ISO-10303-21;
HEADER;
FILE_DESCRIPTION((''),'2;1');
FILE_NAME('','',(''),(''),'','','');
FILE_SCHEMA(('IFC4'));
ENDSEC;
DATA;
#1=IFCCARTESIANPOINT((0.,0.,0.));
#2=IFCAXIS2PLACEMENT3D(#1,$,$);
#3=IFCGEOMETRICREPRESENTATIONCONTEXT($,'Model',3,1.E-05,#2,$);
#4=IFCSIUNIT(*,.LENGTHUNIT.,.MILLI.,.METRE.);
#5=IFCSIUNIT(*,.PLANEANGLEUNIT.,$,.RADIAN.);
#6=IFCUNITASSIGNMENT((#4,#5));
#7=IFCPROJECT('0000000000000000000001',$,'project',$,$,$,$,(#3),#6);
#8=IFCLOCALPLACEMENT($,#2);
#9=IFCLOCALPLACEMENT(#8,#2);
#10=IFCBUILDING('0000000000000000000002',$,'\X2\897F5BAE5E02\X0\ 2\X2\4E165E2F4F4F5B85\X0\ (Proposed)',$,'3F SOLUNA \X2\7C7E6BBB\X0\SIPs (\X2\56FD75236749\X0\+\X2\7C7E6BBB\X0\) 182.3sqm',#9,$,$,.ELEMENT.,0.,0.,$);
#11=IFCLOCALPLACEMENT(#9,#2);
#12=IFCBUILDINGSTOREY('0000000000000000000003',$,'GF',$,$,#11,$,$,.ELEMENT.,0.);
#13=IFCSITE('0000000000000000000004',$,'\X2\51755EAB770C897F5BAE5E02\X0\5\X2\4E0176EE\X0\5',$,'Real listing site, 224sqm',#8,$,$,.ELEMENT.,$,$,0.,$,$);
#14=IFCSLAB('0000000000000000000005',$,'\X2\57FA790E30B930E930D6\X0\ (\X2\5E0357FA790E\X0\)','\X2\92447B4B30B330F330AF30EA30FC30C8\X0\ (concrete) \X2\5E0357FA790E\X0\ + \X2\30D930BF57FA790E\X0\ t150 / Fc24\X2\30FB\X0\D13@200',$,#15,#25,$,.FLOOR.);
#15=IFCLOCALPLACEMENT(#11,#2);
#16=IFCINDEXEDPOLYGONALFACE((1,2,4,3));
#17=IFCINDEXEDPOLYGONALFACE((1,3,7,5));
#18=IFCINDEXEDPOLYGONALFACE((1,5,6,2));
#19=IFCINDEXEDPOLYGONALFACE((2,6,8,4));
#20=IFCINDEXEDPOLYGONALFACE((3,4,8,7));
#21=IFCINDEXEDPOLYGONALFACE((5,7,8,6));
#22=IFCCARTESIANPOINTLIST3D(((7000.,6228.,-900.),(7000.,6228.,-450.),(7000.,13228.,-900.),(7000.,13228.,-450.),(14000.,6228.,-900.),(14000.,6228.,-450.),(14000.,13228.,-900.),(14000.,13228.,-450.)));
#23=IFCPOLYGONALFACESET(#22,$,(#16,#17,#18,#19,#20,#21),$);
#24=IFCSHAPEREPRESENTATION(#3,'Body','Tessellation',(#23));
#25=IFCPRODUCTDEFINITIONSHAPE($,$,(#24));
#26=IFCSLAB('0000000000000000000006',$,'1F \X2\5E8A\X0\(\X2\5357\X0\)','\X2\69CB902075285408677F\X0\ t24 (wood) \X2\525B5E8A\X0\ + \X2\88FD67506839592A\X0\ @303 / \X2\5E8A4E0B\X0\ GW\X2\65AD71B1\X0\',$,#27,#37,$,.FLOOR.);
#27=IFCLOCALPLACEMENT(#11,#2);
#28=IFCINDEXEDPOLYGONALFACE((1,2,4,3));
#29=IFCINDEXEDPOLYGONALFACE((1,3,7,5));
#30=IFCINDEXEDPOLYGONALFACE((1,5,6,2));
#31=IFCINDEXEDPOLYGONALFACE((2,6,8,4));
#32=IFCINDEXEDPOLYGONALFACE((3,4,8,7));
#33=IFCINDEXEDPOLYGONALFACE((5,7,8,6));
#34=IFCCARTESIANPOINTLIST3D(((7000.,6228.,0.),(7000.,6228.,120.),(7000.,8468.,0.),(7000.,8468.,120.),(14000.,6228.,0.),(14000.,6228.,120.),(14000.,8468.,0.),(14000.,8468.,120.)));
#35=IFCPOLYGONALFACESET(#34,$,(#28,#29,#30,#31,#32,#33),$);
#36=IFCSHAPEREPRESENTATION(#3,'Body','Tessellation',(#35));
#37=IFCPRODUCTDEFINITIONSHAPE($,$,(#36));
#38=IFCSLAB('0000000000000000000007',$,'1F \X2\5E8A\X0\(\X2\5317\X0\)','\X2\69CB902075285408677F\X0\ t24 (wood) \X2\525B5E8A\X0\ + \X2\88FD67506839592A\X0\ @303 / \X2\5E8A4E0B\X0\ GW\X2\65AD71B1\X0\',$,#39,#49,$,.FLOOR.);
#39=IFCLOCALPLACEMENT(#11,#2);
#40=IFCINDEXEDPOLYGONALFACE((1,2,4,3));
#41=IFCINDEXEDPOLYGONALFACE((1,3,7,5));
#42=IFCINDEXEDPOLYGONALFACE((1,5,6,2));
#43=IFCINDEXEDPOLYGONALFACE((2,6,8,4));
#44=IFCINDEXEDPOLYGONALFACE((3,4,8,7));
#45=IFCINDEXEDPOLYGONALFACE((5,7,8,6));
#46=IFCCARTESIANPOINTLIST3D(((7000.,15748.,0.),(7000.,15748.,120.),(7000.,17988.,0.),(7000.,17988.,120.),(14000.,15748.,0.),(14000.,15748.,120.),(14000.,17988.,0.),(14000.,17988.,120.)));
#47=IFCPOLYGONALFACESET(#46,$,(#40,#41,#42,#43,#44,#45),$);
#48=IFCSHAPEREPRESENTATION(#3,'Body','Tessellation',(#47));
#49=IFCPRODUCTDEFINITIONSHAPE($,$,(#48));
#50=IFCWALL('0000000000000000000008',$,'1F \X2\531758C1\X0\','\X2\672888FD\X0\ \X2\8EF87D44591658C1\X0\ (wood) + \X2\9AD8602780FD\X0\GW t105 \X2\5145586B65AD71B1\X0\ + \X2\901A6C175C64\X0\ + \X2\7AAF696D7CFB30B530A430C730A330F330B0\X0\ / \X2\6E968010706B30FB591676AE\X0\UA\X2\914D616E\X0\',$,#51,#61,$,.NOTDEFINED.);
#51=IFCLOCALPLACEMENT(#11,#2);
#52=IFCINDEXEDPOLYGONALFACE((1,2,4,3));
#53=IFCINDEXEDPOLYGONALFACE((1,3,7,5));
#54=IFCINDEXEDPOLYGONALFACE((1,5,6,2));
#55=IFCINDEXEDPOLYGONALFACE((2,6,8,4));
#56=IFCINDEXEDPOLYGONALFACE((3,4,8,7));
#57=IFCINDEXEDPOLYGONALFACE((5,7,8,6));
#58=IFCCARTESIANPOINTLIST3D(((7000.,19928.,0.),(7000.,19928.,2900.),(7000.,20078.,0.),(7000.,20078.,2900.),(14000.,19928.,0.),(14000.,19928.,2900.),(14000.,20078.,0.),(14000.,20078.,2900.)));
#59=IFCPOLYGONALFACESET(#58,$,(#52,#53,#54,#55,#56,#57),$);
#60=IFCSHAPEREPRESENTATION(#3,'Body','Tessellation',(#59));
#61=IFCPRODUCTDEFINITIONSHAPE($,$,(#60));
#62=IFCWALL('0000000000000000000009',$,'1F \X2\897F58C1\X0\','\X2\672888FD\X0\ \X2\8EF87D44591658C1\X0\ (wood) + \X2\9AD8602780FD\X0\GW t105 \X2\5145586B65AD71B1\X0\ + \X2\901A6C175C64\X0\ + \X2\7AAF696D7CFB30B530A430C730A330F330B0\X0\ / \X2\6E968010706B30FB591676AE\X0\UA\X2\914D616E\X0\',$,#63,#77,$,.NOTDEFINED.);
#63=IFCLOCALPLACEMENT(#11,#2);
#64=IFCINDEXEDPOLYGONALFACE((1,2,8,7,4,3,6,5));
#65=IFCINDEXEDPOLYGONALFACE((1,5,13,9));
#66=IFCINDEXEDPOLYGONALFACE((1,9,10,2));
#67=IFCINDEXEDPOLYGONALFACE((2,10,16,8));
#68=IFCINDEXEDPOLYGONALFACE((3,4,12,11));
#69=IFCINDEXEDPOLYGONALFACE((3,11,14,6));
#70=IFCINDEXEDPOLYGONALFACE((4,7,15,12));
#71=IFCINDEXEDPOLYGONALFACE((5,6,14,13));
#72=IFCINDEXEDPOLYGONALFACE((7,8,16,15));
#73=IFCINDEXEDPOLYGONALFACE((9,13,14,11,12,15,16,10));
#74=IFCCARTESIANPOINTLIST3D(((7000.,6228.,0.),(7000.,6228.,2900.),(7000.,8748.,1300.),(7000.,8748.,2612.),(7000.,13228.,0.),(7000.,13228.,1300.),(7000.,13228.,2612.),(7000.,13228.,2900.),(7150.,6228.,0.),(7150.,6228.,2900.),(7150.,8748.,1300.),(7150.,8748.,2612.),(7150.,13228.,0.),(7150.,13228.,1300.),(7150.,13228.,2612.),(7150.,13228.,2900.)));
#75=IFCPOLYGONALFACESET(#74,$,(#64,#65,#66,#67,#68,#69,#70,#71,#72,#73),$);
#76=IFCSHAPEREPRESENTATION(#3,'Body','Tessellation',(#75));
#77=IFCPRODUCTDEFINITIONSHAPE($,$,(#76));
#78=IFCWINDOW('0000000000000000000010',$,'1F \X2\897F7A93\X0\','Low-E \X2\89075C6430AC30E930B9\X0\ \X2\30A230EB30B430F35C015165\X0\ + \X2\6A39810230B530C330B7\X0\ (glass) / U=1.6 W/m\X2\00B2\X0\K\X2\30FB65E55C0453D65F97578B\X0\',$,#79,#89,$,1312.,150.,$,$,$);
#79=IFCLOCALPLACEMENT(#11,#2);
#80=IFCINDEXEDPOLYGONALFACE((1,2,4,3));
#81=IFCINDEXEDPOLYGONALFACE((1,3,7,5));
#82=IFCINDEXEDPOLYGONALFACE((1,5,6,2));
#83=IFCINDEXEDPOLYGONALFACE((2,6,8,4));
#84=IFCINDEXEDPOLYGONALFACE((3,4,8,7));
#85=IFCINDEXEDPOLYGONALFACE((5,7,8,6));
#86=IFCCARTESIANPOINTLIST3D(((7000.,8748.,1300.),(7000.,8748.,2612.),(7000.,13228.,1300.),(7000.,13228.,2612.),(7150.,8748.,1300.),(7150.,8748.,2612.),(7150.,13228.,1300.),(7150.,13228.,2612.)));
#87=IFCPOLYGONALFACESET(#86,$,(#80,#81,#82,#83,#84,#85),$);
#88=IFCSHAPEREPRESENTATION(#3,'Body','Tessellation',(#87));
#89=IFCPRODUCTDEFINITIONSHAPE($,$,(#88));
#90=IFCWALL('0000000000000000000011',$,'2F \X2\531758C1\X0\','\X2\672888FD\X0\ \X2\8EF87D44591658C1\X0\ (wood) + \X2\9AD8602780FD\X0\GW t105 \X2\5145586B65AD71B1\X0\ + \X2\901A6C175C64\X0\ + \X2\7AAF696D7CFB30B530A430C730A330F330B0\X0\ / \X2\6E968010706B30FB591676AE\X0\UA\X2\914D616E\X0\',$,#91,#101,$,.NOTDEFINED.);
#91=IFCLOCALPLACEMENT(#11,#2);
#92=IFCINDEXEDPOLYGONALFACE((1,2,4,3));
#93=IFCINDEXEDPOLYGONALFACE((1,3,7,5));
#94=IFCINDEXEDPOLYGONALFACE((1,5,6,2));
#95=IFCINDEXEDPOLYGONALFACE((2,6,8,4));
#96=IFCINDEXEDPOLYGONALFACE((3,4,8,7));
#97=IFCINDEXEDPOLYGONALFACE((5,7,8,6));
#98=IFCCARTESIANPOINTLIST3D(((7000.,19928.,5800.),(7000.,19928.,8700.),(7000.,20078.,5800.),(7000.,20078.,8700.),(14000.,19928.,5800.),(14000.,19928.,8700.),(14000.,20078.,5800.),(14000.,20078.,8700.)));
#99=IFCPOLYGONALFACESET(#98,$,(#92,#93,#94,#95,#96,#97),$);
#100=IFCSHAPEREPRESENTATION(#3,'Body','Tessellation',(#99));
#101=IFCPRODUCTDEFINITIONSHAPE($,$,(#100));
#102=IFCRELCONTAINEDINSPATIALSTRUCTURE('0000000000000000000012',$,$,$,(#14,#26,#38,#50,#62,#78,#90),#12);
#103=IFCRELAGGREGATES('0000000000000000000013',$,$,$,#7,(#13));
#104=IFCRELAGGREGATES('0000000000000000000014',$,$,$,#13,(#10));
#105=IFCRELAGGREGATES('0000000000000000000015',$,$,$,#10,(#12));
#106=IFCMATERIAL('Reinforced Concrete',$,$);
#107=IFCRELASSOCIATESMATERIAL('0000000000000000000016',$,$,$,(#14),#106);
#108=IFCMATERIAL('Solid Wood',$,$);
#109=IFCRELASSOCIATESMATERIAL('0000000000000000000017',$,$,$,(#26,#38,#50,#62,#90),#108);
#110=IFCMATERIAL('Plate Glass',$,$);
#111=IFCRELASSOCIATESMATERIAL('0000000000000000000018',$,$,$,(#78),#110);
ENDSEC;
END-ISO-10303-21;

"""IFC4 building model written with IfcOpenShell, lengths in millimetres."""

from ifc_helpers import new_model, si_unit, frame, frame_2d, origin, place, context, project, spatial, rectangle, extrude, material, element, fill, save


model = new_model("IFC4")

# Units and contexts
model_context = context("Model", 3, precision=1e-05, world=origin())
ifc_project = project(units=[si_unit("LENGTHUNIT", "METRE", prefix="MILLI"), si_unit("PLANEANGLEUNIT", "RADIAN")], contexts=[model_context])

# Site, building, storey
site_placement = place(None, origin())
site = spatial("IfcSite", under=ifc_project, at=site_placement, Name="兵庫県西宮市5丁目5", ObjectType="Real listing site, 224sqm", CompositionType="ELEMENT", RefElevation=0.0)
building_placement = place(site_placement, origin())
building = spatial("IfcBuilding", under=site, at=building_placement, Name="西宮市 2世帯住宅 (Proposed)", ObjectType="3F SOLUNA 籾殻SIPs (国産杉+籾殻) 182.3sqm", CompositionType="ELEMENT", ElevationOfRefHeight=0.0, ElevationOfTerrain=0.0)
storey_placement = place(building_placement, origin())
storey = spatial("IfcBuildingStorey", under=building, at=storey_placement, Name="GF", CompositionType="ELEMENT", Elevation=0.0)

# Slabs
ifc_material_1 = material(Name="Reinforced Concrete")
slab_1_placement = place(storey_placement, frame((3500.0, 3114.0, -450.0)))
element("IfcSlab", 1, at=slab_1_placement, inside=storey, material=ifc_material_1, Name="基礎スラブ (布基礎)", Description="鉄筋コンクリート (concrete) 布基礎 + ベタ基礎 t150 / Fc24・D13@200", PredefinedType="FLOOR", context=model_context, shape_type="SweptSolid", body=[
    extrude(rectangle(XDim=7000.0, YDim=7000.0, at=frame_2d((3500.0, 3500.0))), frame((3500.0, 3114.0, -450.0)), (0.0, 0.0, 1.0), 450.0),
])
ifc_material_2 = material(Name="Solid Wood")
slab_2_placement = place(storey_placement, frame((3500.0, 3114.0, 0.0)))
element("IfcSlab", 2, at=slab_2_placement, inside=storey, material=ifc_material_2, Name="1F 床(南)", Description="構造用合板 t24 (wood) 剛床 + 製材根太 @303 / 床下 GW断熱", PredefinedType="FLOOR", context=model_context, shape_type="SweptSolid", body=[
    extrude(rectangle(XDim=7000.0, YDim=2240.0, at=frame_2d((3500.0, 1120.0))), frame((3500.0, 3114.0, 0.0)), (0.0, 0.0, 1.0), 120.0),
])
slab_3_placement = place(storey_placement, frame((3500.0, 7874.0, 0.0)))
element("IfcSlab", 3, at=slab_3_placement, inside=storey, material=ifc_material_2, Name="1F 床(北)", Description="構造用合板 t24 (wood) 剛床 + 製材根太 @303 / 床下 GW断熱", PredefinedType="FLOOR", context=model_context, shape_type="SweptSolid", body=[
    extrude(rectangle(XDim=7000.0, YDim=2240.0, at=frame_2d((3500.0, 1120.0))), frame((3500.0, 7874.0, 0.0)), (0.0, 0.0, 1.0), 120.0),
])

# Shared definitions
ifc_material_3 = material(Name="Plate Glass")

# Wall
wall_1_placement = place(storey_placement, frame((3500.0, 9964.0, 0.0)))
element("IfcWall", 4, at=wall_1_placement, inside=storey, material=ifc_material_2, Name="1F 北壁", Description="木製 軸組外壁 (wood) + 高性能GW t105 充填断熱 + 通気層 + 窯業系サイディング / 準耐火・外皮UA配慮", PredefinedType="NOTDEFINED", context=model_context, shape_type="SweptSolid", body=[
    extrude(rectangle(XDim=7000.0, YDim=150.0, at=frame_2d((3500.0, 75.0))), frame((3500.0, 9964.0, 0.0)), (0.0, 0.0, 1.0), 2900.0),
])

# Wall, opening, window
wall_2_placement = place(storey_placement, frame((3500.0, 3114.0, 0.0)))
wall_2 = element("IfcWall", 5, at=wall_2_placement, inside=storey, material=ifc_material_2, Name="1F 西壁", Description="木製 軸組外壁 (wood) + 高性能GW t105 充填断熱 + 通気層 + 窯業系サイディング / 準耐火・外皮UA配慮", PredefinedType="NOTDEFINED", context=model_context, shape_type="SweptSolid", body=[
    extrude(rectangle(XDim=150.0, YDim=7000.0, at=frame_2d((75.0, 3500.0))), frame((3500.0, 3114.0, 0.0)), (0.0, 0.0, 1.0), 2900.0),
])
opening_1_placement = place(storey_placement, frame((3500.0, 4374.0, 650.0)))
opening_1 = element("IfcOpeningElement", 6, at=opening_1_placement, cuts=wall_2, PredefinedType="NOTDEFINED", context=model_context, shape_type="SweptSolid", body=[
    extrude(rectangle(XDim=150.0, YDim=4480.0, at=frame_2d((75.0, 2240.0))), frame((3500.0, 4374.0, 650.0)), (0.0, 0.0, 1.0), 1312.0),
])
window_1_placement = place(storey_placement, frame((3500.0, 4374.0, 650.0)))
window_1 = element("IfcWindow", 7, at=window_1_placement, inside=storey, material=ifc_material_3, Name="1F 西窓", Description="Low-E 複層ガラス アルゴン封入 + 樹脂サッシ (glass) / U=1.6 W/m²K・日射取得型", OverallHeight=1312.0, OverallWidth=150.0, context=model_context, shape_type="SweptSolid", body=[
    extrude(rectangle(XDim=150.0, YDim=4480.0, at=frame_2d((75.0, 2240.0))), frame((3500.0, 4374.0, 650.0)), (0.0, 0.0, 1.0), 1312.0),
])
fill(opening_1, window_1)

# Wall
wall_3_placement = place(storey_placement, frame((3500.0, 9964.0, 2900.0)))
element("IfcWall", 8, at=wall_3_placement, inside=storey, material=ifc_material_2, Name="2F 北壁", Description="木製 軸組外壁 (wood) + 高性能GW t105 充填断熱 + 通気層 + 窯業系サイディング / 準耐火・外皮UA配慮", PredefinedType="NOTDEFINED", context=model_context, shape_type="SweptSolid", body=[
    extrude(rectangle(XDim=7000.0, YDim=150.0, at=frame_2d((3500.0, 75.0))), frame((3500.0, 9964.0, 2900.0)), (0.0, 0.0, 1.0), 2900.0),
])

save(model, "model.ifc")
